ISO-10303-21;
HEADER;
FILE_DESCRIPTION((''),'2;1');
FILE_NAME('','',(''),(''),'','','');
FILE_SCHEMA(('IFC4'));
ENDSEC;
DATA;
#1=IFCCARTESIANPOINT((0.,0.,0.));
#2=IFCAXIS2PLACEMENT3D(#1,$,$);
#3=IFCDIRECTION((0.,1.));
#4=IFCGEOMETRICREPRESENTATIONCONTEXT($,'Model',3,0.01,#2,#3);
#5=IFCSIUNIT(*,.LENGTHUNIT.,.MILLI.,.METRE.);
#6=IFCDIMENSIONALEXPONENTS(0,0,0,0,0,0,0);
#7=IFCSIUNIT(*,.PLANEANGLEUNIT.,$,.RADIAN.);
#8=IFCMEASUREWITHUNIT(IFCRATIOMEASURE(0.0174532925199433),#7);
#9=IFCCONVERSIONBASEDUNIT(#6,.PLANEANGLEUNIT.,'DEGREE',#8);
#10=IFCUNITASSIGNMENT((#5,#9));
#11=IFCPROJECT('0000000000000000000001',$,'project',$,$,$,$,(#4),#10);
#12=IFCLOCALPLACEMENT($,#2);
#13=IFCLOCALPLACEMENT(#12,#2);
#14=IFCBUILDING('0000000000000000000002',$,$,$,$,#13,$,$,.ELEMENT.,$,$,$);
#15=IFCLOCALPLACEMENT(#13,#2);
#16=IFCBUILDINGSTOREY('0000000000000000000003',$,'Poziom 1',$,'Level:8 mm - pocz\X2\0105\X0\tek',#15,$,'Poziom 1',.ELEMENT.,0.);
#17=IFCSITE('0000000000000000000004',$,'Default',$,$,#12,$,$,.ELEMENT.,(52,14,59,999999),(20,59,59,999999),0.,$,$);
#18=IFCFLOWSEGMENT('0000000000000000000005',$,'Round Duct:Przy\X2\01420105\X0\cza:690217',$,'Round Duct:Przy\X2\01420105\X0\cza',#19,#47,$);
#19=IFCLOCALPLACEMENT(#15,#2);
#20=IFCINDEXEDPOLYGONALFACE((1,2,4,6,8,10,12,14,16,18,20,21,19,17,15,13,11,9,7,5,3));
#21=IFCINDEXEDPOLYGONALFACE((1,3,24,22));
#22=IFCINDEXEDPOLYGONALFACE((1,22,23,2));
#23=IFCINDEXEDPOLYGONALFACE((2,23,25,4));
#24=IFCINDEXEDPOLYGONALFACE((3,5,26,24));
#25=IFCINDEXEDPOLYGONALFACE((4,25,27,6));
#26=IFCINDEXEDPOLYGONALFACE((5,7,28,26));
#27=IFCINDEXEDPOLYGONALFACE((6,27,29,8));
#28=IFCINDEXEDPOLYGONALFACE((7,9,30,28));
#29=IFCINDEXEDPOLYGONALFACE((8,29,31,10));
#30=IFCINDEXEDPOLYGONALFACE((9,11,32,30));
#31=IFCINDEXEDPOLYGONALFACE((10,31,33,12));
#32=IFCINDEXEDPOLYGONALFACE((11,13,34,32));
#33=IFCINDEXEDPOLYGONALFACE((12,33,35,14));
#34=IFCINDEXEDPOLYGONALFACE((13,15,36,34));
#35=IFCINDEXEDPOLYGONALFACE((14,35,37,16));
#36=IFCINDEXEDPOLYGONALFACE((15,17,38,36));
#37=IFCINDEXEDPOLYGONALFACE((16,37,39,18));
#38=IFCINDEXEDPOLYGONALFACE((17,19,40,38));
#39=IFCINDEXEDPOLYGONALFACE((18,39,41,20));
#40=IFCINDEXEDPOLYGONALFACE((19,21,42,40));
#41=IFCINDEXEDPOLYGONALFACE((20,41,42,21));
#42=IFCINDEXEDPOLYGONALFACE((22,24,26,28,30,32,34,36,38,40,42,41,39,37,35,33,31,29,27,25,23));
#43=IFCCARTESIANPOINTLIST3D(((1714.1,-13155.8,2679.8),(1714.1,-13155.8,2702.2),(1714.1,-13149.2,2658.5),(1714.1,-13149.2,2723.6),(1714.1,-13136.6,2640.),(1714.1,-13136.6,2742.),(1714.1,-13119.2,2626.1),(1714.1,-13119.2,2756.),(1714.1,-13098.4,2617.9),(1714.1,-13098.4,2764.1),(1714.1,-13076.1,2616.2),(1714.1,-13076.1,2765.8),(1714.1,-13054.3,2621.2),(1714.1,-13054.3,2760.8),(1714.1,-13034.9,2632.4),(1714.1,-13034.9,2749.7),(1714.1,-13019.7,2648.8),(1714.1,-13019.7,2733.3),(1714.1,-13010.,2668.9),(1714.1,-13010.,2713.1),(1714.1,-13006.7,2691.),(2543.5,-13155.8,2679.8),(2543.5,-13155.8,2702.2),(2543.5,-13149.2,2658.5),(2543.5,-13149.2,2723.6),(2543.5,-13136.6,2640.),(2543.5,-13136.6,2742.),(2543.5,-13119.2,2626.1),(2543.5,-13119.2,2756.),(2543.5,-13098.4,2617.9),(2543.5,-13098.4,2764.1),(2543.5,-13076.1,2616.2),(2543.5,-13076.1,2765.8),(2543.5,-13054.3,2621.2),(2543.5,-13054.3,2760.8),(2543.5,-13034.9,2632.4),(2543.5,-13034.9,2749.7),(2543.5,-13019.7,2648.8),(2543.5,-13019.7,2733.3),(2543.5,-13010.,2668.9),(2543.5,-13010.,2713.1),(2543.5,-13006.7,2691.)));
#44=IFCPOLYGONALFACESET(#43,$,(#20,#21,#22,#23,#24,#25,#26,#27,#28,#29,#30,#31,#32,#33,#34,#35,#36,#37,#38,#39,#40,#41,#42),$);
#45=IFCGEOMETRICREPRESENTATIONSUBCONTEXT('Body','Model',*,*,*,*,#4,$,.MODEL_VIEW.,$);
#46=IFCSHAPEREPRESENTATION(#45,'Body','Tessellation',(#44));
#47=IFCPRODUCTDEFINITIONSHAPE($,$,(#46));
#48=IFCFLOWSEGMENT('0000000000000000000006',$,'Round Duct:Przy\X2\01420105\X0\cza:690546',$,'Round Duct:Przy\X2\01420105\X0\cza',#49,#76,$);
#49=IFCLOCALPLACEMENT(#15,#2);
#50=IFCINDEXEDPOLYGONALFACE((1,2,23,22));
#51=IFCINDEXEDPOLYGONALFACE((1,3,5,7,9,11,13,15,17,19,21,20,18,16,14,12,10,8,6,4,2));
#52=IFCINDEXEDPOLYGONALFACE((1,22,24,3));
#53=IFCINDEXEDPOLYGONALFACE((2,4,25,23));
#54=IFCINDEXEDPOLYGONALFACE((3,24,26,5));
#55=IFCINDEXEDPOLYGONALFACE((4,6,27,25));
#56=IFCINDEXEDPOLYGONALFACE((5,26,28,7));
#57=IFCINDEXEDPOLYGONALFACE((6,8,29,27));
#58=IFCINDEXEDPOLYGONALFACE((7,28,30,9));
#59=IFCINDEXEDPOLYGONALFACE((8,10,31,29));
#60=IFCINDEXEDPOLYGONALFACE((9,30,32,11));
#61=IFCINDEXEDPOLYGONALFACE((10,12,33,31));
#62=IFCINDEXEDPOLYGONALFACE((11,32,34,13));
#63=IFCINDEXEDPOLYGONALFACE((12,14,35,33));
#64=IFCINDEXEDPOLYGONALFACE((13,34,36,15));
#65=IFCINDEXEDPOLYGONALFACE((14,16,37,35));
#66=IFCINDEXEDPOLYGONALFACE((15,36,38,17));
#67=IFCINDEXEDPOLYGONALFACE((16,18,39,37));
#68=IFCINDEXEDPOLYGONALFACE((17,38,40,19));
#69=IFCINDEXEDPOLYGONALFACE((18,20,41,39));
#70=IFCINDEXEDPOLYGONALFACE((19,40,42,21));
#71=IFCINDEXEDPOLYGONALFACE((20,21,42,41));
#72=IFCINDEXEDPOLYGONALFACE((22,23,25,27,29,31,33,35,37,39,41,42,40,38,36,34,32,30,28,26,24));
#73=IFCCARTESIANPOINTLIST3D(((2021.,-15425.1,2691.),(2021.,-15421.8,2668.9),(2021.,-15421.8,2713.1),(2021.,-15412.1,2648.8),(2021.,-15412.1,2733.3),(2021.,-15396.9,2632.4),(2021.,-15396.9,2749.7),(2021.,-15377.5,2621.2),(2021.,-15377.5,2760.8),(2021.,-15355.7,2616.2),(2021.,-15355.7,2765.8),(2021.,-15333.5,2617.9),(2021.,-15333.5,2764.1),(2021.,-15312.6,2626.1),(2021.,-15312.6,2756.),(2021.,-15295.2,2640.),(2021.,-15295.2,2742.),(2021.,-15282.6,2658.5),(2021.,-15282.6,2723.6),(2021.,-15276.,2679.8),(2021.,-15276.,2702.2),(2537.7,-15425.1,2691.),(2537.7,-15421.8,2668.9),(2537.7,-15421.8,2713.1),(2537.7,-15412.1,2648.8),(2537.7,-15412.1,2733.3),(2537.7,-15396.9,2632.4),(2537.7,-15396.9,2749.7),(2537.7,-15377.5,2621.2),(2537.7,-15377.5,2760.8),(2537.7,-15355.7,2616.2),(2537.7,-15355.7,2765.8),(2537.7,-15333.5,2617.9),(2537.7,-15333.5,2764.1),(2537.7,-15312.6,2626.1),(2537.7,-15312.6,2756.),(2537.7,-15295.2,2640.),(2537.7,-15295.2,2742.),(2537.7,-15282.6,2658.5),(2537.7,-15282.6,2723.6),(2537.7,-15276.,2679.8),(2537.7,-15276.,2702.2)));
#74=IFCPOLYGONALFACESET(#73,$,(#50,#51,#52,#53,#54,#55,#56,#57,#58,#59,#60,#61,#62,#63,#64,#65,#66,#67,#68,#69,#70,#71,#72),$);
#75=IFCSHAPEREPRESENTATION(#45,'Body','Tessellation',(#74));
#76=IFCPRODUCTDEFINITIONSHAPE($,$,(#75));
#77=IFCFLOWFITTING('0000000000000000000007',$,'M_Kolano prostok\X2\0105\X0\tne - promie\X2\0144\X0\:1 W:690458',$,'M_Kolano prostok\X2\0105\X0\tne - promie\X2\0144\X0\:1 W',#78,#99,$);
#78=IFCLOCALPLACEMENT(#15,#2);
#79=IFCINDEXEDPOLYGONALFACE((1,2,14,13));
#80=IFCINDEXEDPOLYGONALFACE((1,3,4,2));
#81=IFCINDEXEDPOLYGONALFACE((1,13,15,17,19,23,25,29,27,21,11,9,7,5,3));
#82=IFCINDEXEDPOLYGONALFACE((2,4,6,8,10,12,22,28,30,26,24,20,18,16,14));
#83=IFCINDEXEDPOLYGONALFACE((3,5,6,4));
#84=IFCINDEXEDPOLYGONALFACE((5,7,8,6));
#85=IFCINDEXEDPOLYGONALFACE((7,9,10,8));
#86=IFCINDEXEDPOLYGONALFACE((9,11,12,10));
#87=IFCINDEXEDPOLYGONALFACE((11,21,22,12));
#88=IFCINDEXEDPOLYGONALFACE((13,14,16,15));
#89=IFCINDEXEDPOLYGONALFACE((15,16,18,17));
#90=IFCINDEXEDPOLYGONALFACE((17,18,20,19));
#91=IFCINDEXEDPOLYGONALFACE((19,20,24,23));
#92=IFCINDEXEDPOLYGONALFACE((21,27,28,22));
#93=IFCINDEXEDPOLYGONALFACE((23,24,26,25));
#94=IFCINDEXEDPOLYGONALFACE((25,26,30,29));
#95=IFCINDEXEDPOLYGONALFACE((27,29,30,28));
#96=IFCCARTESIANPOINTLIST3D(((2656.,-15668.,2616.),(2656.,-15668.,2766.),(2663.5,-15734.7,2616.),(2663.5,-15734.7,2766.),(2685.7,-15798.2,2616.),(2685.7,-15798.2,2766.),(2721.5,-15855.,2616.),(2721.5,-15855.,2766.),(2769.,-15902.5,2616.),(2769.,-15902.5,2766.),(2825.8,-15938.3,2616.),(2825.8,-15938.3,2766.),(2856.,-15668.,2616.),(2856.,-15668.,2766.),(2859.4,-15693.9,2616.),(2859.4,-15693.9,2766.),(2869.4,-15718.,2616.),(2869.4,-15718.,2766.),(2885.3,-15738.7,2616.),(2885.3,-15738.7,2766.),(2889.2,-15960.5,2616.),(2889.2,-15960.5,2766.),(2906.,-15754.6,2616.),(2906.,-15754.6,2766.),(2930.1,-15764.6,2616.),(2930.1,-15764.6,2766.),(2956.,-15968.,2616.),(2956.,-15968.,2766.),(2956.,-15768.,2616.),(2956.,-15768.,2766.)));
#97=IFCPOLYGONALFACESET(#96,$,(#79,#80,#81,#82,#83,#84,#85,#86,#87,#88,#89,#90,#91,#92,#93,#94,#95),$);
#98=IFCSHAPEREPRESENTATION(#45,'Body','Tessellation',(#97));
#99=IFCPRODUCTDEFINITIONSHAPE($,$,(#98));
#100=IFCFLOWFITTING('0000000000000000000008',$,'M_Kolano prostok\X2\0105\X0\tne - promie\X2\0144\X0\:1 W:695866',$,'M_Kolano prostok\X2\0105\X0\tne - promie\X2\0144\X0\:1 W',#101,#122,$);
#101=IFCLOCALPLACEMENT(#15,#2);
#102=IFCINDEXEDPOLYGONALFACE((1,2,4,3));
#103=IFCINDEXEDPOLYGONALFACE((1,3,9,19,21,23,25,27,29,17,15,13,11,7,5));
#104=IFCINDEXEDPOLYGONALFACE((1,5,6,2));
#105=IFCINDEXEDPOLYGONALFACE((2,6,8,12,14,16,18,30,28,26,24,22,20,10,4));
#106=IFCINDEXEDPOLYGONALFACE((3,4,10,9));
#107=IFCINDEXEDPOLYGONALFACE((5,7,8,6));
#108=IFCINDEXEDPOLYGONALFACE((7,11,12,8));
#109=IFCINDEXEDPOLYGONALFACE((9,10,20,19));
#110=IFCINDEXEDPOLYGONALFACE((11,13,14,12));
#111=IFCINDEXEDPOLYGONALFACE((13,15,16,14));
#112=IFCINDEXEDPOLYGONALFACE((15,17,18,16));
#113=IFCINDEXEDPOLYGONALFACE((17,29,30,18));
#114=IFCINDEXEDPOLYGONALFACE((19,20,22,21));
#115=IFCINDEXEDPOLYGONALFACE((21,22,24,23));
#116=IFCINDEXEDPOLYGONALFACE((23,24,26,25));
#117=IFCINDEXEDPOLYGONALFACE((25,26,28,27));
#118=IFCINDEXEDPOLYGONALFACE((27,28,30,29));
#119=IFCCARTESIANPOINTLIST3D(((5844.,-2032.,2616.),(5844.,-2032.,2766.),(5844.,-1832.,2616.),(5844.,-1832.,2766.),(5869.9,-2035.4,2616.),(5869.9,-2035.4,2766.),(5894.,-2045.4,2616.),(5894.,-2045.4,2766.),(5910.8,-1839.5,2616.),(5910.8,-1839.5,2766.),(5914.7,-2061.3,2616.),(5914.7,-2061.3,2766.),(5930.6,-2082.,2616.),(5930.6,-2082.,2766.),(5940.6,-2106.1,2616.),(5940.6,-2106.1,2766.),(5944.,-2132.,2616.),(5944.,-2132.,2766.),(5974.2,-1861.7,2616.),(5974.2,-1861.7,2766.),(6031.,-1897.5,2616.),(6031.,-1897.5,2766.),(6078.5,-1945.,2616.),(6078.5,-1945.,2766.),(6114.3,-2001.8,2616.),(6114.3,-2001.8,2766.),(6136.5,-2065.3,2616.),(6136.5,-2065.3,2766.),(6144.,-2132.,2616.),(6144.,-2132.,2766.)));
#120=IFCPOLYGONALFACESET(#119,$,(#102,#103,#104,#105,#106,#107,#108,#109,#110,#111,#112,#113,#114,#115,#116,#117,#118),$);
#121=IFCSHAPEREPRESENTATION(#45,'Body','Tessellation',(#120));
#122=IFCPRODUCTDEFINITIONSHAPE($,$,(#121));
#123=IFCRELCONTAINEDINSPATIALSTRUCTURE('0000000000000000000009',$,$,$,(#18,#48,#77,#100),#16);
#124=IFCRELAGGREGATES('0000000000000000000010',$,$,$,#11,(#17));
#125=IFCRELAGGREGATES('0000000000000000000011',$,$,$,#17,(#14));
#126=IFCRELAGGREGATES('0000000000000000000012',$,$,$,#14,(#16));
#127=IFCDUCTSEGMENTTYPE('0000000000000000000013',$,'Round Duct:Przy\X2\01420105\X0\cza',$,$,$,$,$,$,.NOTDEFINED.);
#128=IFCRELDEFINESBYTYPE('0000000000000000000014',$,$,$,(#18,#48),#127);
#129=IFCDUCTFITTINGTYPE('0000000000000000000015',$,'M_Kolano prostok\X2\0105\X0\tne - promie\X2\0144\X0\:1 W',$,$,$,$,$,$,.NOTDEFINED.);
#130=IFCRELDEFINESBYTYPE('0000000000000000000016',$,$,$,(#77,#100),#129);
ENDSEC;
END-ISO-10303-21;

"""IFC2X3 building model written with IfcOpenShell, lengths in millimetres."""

from ifc_helpers import new_model, entity, si_unit, converted_unit, direction, frame, frame_2d, origin, origin_2d_with_axis, place, context, subcontext, project, spatial, polyline, circle_curve, parameter, trimmed, segment, composite_curve, circle, outline, extrude, source, transform, mapped, type_object, type_shapes, element, save


model = new_model("IFC2X3")

# Units and contexts
model_context = context("Model", 3, precision=0.01, world=origin(), true_north=direction((0.0, 1.0)))
body_context = subcontext(model_context, "Body", "Model", "MODEL_VIEW")
ifc_project = project(units=[si_unit("LENGTHUNIT", "METRE", prefix="MILLI"), converted_unit("PLANEANGLEUNIT", "DEGREE", entity("IfcRatioMeasure", 0.0174532925199433), si_unit("PLANEANGLEUNIT", "RADIAN"), dimensions=[0, 0, 0, 0, 0, 0, 0])], contexts=[model_context])

# Site, building, storey
site_placement = place(None, origin())
site = spatial("IfcSite", under=ifc_project, at=site_placement, Name="Default", CompositionType="ELEMENT", RefLatitude=(52, 14, 59, 999999), RefLongitude=(20, 59, 59, 999999), RefElevation=0.0)
building_placement = place(site_placement, origin())
building = spatial("IfcBuilding", under=site, at=building_placement, CompositionType="ELEMENT")
storey_placement = place(building_placement, origin())
storey = spatial("IfcBuildingStorey", under=building, at=storey_placement, Name="Poziom 1", ObjectType="Level:8 mm - początek", LongName="Poziom 1", CompositionType="ELEMENT", Elevation=0.0)

# Flow segments
duct_segment_type_1 = type_object("IfcDuctSegmentType", Name="Round Duct:Przyłącza", PredefinedType="NOTDEFINED")
flow_segment_1_placement = place(storey_placement, origin())
element("IfcFlowSegment", 1, at=flow_segment_1_placement, inside=storey, type_object=duct_segment_type_1, Name="Round Duct:Przyłącza:690217", ObjectType="Round Duct:Przyłącza", context=body_context, shape_type="SweptSolid", body=[
    extrude(circle(Radius=75.0, at=frame_2d((0.0, 0.0), x_axis=(1.0, 0.0))), frame((1714.1, -13081.7, 2691.0), z_axis=(1.0, 0.0, 0.0), x_axis=(0.0, 1.0, 0.0)), (0.0, 0.0, 1.0), 829.4),
])
flow_segment_2_placement = place(storey_placement, origin())
element("IfcFlowSegment", 2, at=flow_segment_2_placement, inside=storey, type_object=duct_segment_type_1, Name="Round Duct:Przyłącza:690546", ObjectType="Round Duct:Przyłącza", context=body_context, shape_type="SweptSolid", body=[
    extrude(circle(Radius=75.0, at=origin_2d_with_axis()), frame((2021.0, -15350.1, 2691.0), z_axis=(1.0, 0.0, 0.0), x_axis=(0.0, -1.0, 0.0)), (0.0, 0.0, 1.0), 516.7),
])

# Flow fittings
duct_fitting_type_1 = type_object("IfcDuctFittingType", Name="M_Kolano prostokątne - promień:1 W", PredefinedType="NOTDEFINED")
shared_shape_1 = source(origin(), body_context, "Body", "SweptSolid", [
    extrude(outline(composite_curve([segment(polyline([(-200.0, -100.0), (0.0, -100.0)]), True, "CONTINUOUS"), segment(trimmed(circle_curve(frame_2d((100.0, -100.0), x_axis=(0.0, 1.0)), 100.0), [parameter(0.0)], [parameter(90.0)], True, "PARAMETER"), False, "CONTINUOUS"), segment(polyline([(100.0, 0.0), (100.0, 200.0)]), True, "CONTINUOUS"), segment(trimmed(circle_curve(frame_2d((100.0, -100.0), x_axis=(0.0, 1.0)), 300.0), [parameter(0.0)], [parameter(90.0)], True, "PARAMETER"), True, "CONTINUOUS")], self_intersect=False)), frame((-100.0, 100.0, -75.0), z_axis=(0.0, 0.0, 1.0), x_axis=(-1.0, 0.0, 0.0)), (0.0, 0.0, 1.0), 150.0),
])
type_shapes(duct_fitting_type_1, [shared_shape_1])
for number, where, z_axis, x_axis, name in (
    (3, (2756.0, -15868.0, 2691.0), (0.0, 0.0, 1.0), (0.0, -1.0, 0.0), "M_Kolano prostokątne - promień:1 W:690458"),
    (4, (6044.0, -1932.0, 2691.0), (0.0, 0.0, 1.0), (0.0, 1.0, 0.0), "M_Kolano prostokątne - promień:1 W:695866"),
):
    element("IfcFlowFitting", number, at=place(storey_placement, frame(where, z_axis=z_axis, x_axis=x_axis)), inside=storey, type_object=duct_fitting_type_1, Name=name, ObjectType="M_Kolano prostokątne - promień:1 W", context=body_context, shape_type="MappedRepresentation", body=[
        mapped(shared_shape_1, transform((0.0, 0.0, 0.0), scale=1.0)),
    ])

save(model, "model.ifc")
